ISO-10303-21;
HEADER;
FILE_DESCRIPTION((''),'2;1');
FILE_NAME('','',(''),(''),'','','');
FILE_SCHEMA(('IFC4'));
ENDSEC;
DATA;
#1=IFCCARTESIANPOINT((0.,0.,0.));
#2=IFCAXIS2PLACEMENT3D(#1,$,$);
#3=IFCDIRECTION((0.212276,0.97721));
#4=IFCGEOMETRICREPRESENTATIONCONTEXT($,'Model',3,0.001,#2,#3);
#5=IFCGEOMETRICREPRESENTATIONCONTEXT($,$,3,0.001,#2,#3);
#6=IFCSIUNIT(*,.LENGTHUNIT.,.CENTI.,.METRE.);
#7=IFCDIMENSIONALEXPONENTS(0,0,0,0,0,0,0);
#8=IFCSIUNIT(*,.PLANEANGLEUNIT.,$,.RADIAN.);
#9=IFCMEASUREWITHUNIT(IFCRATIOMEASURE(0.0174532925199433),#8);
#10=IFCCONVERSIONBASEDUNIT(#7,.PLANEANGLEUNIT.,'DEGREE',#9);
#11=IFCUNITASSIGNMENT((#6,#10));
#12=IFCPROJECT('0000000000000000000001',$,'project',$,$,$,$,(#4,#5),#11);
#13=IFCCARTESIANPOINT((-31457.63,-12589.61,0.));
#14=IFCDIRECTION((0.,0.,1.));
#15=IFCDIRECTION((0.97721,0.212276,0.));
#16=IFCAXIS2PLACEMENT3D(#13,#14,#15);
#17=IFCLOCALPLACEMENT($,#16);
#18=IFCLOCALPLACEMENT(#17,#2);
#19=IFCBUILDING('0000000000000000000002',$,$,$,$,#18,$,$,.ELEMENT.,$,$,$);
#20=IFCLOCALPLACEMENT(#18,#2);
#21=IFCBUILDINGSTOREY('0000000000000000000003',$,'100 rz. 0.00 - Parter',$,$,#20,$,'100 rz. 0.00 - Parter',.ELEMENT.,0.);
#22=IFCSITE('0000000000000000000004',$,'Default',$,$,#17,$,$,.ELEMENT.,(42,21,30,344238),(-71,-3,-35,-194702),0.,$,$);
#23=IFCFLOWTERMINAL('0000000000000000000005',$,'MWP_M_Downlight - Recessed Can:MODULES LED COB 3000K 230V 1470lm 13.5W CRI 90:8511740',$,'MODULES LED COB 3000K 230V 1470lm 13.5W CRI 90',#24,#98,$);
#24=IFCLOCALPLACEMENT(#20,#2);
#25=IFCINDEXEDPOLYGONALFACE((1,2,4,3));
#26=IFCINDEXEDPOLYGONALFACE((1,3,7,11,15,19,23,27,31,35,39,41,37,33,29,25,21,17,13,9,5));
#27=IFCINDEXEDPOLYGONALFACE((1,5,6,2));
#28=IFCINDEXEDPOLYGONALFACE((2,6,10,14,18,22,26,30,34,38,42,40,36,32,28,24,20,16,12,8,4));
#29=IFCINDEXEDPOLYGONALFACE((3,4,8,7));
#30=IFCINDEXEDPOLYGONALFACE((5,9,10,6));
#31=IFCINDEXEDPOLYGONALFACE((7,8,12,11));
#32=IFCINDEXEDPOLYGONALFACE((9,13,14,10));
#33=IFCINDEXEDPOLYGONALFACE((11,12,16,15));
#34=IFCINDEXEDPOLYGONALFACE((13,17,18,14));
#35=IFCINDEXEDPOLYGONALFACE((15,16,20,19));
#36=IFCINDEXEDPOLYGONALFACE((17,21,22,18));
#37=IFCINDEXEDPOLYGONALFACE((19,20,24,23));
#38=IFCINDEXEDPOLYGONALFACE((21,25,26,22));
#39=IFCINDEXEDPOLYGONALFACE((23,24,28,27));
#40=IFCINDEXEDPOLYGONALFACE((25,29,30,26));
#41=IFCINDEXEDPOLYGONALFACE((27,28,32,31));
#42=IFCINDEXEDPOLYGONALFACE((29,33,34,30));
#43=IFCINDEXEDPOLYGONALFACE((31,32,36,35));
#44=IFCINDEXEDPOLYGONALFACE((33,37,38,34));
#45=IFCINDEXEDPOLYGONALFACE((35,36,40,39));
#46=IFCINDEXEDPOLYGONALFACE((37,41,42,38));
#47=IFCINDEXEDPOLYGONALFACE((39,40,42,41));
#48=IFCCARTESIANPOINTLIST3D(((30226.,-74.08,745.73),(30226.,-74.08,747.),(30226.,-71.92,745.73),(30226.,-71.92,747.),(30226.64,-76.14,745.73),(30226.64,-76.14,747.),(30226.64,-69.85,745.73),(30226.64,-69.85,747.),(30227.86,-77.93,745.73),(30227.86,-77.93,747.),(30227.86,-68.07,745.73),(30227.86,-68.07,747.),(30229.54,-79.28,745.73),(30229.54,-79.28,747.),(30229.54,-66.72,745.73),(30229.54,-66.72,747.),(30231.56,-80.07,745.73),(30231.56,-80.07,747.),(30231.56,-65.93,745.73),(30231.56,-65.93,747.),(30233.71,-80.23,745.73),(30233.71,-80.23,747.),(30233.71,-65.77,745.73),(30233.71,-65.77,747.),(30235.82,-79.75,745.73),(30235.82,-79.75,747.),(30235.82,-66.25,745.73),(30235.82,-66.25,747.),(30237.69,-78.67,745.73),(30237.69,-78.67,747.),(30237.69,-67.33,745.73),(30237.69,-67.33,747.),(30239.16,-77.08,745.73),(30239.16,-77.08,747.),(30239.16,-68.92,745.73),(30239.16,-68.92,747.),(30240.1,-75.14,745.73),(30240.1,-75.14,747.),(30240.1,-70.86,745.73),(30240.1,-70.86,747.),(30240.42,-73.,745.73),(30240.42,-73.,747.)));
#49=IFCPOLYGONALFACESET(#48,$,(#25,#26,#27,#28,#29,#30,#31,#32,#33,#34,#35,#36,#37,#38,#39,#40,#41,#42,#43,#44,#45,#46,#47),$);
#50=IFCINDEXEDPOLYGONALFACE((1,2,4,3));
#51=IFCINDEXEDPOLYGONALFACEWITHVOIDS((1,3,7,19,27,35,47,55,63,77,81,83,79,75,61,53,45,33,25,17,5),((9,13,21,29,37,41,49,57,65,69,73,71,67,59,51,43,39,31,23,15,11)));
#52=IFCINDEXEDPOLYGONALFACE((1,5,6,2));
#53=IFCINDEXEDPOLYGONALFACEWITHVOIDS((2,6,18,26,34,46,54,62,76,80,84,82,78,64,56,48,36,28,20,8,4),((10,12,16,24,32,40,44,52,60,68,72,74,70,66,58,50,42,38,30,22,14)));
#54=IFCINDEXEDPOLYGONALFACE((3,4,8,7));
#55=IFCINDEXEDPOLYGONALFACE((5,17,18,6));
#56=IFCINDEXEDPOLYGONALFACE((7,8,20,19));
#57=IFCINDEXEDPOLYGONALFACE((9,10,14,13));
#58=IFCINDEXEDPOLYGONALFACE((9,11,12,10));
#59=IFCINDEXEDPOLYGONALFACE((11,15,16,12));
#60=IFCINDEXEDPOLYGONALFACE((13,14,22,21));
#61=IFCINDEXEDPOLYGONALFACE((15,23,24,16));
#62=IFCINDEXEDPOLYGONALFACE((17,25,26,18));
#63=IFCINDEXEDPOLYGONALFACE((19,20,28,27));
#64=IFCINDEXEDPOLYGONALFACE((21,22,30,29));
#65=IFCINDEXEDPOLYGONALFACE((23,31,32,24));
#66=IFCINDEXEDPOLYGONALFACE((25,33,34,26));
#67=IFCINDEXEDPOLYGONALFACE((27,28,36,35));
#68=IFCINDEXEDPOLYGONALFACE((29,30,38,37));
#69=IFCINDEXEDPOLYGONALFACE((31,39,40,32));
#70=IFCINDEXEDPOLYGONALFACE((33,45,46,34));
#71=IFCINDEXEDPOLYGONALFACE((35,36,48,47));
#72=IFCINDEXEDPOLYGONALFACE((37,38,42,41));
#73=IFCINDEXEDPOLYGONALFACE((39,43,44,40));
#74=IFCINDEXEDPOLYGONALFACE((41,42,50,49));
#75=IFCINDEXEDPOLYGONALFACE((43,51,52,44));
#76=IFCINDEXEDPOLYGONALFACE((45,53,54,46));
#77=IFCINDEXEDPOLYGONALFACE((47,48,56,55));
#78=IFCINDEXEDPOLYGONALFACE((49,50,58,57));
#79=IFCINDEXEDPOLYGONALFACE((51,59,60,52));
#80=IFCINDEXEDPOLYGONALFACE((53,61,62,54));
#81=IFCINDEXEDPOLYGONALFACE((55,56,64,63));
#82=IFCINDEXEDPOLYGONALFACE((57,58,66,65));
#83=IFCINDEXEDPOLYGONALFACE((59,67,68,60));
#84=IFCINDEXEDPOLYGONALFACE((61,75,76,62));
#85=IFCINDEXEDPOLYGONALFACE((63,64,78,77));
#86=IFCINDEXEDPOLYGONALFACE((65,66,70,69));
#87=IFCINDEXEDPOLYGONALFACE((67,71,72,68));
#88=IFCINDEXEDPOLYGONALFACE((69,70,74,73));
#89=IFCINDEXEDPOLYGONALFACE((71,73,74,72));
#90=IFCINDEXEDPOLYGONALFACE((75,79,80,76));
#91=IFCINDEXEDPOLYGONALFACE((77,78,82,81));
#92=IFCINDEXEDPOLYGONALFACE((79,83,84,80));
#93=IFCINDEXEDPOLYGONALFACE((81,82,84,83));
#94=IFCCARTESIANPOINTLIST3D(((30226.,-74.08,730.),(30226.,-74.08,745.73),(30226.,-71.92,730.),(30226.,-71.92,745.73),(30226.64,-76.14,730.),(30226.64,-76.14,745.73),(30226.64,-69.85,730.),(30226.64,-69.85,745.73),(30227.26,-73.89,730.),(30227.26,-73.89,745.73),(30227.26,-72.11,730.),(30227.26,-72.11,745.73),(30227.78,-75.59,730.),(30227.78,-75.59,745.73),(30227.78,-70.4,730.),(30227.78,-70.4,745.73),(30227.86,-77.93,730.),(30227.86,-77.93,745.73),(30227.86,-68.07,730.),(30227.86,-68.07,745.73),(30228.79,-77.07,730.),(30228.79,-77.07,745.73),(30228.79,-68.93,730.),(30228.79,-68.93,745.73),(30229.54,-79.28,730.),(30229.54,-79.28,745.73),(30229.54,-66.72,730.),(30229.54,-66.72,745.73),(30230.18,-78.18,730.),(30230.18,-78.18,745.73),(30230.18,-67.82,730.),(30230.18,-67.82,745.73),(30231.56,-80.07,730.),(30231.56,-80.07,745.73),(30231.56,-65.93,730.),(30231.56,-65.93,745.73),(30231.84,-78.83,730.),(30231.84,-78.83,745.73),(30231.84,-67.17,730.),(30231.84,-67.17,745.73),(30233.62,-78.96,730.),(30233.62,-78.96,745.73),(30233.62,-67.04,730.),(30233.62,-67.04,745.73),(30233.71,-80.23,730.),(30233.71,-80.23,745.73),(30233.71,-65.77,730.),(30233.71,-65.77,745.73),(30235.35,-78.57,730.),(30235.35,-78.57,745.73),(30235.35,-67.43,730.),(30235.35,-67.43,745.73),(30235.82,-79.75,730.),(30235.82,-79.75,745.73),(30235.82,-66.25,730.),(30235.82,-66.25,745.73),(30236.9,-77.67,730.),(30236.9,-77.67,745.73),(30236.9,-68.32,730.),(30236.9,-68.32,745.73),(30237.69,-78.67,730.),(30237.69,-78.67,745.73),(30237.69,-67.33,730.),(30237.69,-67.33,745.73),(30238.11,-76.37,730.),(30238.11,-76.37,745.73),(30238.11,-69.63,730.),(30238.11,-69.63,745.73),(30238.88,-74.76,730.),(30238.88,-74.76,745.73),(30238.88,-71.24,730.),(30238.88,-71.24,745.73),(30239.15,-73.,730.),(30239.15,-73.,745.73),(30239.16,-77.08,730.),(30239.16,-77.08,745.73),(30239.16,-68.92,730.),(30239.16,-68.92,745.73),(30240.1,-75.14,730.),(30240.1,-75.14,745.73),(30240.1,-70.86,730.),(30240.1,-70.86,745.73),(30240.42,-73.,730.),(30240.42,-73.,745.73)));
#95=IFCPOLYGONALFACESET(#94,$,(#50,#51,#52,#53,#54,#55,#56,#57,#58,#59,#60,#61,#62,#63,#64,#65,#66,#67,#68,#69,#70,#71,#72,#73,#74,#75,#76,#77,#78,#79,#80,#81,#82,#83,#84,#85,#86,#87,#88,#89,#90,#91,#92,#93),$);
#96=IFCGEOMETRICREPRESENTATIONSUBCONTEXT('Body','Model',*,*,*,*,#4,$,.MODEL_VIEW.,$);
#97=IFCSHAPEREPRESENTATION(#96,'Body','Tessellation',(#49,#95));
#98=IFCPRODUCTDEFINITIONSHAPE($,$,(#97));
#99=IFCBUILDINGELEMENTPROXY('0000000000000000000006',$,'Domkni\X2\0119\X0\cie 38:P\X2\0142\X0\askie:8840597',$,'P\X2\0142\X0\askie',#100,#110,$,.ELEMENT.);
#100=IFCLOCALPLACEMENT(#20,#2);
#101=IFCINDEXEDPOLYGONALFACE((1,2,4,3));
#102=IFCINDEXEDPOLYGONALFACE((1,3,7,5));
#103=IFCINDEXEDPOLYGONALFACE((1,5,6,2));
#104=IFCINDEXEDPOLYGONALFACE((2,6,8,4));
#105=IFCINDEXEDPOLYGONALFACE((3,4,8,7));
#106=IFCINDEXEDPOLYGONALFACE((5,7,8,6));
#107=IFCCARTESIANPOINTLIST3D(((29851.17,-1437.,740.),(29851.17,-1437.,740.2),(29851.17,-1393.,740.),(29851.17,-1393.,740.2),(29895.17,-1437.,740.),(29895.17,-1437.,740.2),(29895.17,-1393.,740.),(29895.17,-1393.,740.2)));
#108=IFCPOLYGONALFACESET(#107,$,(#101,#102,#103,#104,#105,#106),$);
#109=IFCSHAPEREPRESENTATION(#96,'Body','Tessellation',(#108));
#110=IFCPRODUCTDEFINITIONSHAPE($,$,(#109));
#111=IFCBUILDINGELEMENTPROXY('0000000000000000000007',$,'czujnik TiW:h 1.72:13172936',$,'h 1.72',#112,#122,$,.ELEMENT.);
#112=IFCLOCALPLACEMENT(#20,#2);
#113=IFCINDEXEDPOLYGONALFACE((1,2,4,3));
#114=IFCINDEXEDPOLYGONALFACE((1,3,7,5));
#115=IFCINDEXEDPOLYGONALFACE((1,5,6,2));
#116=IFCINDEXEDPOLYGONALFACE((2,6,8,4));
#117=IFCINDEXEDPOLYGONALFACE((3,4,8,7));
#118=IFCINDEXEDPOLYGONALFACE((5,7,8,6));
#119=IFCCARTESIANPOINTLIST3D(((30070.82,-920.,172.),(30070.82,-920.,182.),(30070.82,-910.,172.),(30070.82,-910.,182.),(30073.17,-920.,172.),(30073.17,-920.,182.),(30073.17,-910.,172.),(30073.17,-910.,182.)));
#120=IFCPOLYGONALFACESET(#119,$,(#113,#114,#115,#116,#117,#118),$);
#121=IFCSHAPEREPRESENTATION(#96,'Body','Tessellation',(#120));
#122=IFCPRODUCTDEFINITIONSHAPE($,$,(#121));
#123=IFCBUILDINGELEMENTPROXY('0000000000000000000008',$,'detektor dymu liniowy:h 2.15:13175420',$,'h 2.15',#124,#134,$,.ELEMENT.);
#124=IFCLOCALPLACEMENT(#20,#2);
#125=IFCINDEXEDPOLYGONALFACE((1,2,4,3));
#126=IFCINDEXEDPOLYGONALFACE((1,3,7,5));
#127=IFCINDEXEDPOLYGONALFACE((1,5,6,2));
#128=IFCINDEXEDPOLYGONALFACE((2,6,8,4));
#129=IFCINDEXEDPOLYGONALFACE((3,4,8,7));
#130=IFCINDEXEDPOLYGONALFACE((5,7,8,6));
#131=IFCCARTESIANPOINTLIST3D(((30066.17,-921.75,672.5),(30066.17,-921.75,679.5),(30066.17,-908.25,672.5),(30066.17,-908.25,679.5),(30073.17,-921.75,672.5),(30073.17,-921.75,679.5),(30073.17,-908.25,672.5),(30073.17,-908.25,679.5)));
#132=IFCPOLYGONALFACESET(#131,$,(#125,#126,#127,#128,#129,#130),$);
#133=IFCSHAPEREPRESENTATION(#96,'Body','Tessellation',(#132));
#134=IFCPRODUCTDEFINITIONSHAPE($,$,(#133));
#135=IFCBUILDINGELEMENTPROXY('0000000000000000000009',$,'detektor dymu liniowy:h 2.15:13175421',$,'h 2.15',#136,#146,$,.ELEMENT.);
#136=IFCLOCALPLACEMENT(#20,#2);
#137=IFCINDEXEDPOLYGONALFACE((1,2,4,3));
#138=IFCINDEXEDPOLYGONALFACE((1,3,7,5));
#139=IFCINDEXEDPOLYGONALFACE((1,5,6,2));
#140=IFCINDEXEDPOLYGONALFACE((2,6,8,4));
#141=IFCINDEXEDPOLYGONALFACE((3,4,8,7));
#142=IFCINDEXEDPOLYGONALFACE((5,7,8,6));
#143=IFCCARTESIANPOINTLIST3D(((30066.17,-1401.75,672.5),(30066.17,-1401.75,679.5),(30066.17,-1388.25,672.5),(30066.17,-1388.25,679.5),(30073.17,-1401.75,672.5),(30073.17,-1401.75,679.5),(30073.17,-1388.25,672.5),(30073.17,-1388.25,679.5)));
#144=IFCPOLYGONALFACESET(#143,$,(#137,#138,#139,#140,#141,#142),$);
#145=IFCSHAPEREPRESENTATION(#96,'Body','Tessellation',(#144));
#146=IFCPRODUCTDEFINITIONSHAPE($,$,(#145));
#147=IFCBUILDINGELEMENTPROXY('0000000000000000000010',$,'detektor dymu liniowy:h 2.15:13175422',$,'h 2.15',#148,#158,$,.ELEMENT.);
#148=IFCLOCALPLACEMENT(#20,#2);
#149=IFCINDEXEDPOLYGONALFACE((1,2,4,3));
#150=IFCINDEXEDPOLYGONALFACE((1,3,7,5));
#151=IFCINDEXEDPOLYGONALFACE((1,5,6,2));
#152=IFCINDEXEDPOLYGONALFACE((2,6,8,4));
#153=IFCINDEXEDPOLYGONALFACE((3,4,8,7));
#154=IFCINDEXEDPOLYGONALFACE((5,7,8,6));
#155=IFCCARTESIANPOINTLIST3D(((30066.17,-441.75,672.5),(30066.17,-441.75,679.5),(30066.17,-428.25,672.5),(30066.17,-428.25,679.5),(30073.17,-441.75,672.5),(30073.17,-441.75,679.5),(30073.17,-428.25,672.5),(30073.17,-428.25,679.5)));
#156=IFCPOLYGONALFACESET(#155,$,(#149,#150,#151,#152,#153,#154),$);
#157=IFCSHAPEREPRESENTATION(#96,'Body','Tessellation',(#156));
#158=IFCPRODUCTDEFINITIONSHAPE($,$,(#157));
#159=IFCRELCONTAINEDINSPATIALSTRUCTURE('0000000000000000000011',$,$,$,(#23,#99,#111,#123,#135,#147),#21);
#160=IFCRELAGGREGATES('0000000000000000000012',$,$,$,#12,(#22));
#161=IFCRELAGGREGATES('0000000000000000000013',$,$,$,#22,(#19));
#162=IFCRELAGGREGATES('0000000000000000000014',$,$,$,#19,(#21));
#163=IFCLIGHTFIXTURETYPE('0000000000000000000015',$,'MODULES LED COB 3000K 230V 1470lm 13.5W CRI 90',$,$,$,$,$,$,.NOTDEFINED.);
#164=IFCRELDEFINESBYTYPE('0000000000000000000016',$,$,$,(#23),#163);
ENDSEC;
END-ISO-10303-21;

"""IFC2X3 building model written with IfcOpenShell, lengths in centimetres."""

from ifc_helpers import new_model, entity, si_unit, converted_unit, direction, frame, frame_2d, origin, origin_2d_with_axis, place, context, subcontext, project, spatial, rectangle, circle, hollow_circle, extrude, source, transform, mapped, type_object, type_shapes, element, save


model = new_model("IFC2X3")

# Units and contexts
model_context = context("Model", 3, precision=0.001, world=origin(), true_north=direction((0.212276, 0.97721)))
context_of_model = context(None, 3, precision=0.001, world=origin(), true_north=direction((0.212276, 0.97721)))
body_context = subcontext(model_context, "Body", "Model", "MODEL_VIEW")
ifc_project = project(units=[si_unit("LENGTHUNIT", "METRE", prefix="CENTI"), converted_unit("PLANEANGLEUNIT", "DEGREE", entity("IfcRatioMeasure", 0.0174532925199433), si_unit("PLANEANGLEUNIT", "RADIAN"), dimensions=[0, 0, 0, 0, 0, 0, 0])], contexts=[model_context, context_of_model])

# Site, building, storey
site_placement = place(None, frame((-31457.63, -12589.61, 0.0), z_axis=(0.0, 0.0, 1.0), x_axis=(0.97721, 0.212276, 0.0)))
site = spatial("IfcSite", under=ifc_project, at=site_placement, Name="Default", CompositionType="ELEMENT", RefLatitude=(42, 21, 30, 344238), RefLongitude=(-71, -3, -35, -194702), RefElevation=0.0)
building_placement = place(site_placement, origin())
building = spatial("IfcBuilding", under=site, at=building_placement, CompositionType="ELEMENT")
storey_placement = place(building_placement, origin())
storey = spatial("IfcBuildingStorey", under=building, at=storey_placement, Name="100 rz. 0.00 - Parter", LongName="100 rz. 0.00 - Parter", CompositionType="ELEMENT", Elevation=0.0)

# Flow terminal
light_fixture_type_1 = type_object("IfcLightFixtureType", Name="MODULES LED COB 3000K 230V 1470lm 13.5W CRI 90", PredefinedType="NOTDEFINED")
shared_shape_1 = source(origin(), body_context, "Body", "SweptSolid", [
    extrude(circle(Radius=7.25, at=frame_2d((0.0, 0.0), x_axis=(1.0, 0.0))), frame((7.41, 7.41, 15.73)), (0.0, 0.0, 1.0), 1.27),
    extrude(hollow_circle(Radius=7.25, WallThickness=1.27, at=frame_2d((0.0, 0.0), x_axis=(1.0, 0.0))), frame((7.41, 7.41, 0.0)), (0.0, 0.0, 1.0), 15.73),
])
type_shapes(light_fixture_type_1, [shared_shape_1])
for number, where, name in (
    (1, (30225.76, -80.41, 730.0), "MWP_M_Downlight - Recessed Can:MODULES LED COB 3000K 230V 1470lm 13.5W CRI 90:8511740"),
):
    element("IfcFlowTerminal", number, at=place(storey_placement, frame(where)), inside=storey, type_object=light_fixture_type_1, Name=name, ObjectType="MODULES LED COB 3000K 230V 1470lm 13.5W CRI 90", context=body_context, shape_type="MappedRepresentation", body=[
        mapped(shared_shape_1, transform((0.0, 0.0, 0.0), scale=1.0)),
    ])

# Building element proxies
shared_shape_2 = source(origin(), body_context, "Body", "SweptSolid", [
    extrude(rectangle(XDim=44.0, YDim=44.0, at=origin_2d_with_axis()), frame((22.0, 22.0, 0.0), z_axis=(0.0, 0.0, 1.0), x_axis=(-1.0, 0.0, 0.0)), (0.0, 0.0, 1.0), 0.2),
])
proxy_1_placement = place(storey_placement, frame((29851.17, -1437.0, 740.0)))
element("IfcBuildingElementProxy", 2, at=proxy_1_placement, inside=storey, Name="Domknięcie 38:Płaskie:8840597", ObjectType="Płaskie", CompositionType="ELEMENT", context=body_context, shape_type="MappedRepresentation", body=[
    mapped(shared_shape_2, transform((0.0, 0.0, 0.0), scale=1.0)),
])
shared_shape_3 = source(origin(), body_context, "Body", "SweptSolid", [
    extrude(rectangle(XDim=2.35, YDim=10.0, at=origin_2d_with_axis()), frame((5.0, 1.18, 0.0), z_axis=(0.0, 0.0, 1.0), x_axis=(0.0, 1.0, 0.0)), (0.0, 0.0, 1.0), 10.0),
])
proxy_2_placement = place(storey_placement, frame((30070.82, -910.0, 172.0), z_axis=(0.0, 0.0, 1.0), x_axis=(0.0, -1.0, 0.0)))
element("IfcBuildingElementProxy", 3, at=proxy_2_placement, inside=storey, Name="czujnik TiW:h 1.72:13172936", ObjectType="h 1.72", CompositionType="ELEMENT", context=body_context, shape_type="MappedRepresentation", body=[
    mapped(shared_shape_3, transform((0.0, 0.0, 0.0), scale=1.0)),
])
shared_shape_4 = source(origin(), body_context, "Body", "SweptSolid", [
    extrude(rectangle(XDim=7.0, YDim=13.5, at=origin_2d_with_axis()), frame((6.75, 3.5, 0.0), z_axis=(0.0, 0.0, 1.0), x_axis=(0.0, 1.0, 0.0)), (0.0, 0.0, 1.0), 7.0),
])
for number, where, z_axis, x_axis, name in (
    (4, (30066.17, -908.25, 672.5), (0.0, 0.0, 1.0), (0.0, -1.0, 0.0), "detektor dymu liniowy:h 2.15:13175420"),
    (5, (30066.17, -1388.25, 672.5), (0.0, 0.0, 1.0), (0.0, -1.0, 0.0), "detektor dymu liniowy:h 2.15:13175421"),
    (6, (30066.17, -428.25, 672.5), (0.0, 0.0, 1.0), (0.0, -1.0, 0.0), "detektor dymu liniowy:h 2.15:13175422"),
):
    element("IfcBuildingElementProxy", number, at=place(storey_placement, frame(where, z_axis=z_axis, x_axis=x_axis)), inside=storey, Name=name, ObjectType="h 2.15", CompositionType="ELEMENT", context=body_context, shape_type="MappedRepresentation", body=[
        mapped(shared_shape_4, transform((0.0, 0.0, 0.0), scale=1.0)),
    ])

save(model, "model.ifc")
